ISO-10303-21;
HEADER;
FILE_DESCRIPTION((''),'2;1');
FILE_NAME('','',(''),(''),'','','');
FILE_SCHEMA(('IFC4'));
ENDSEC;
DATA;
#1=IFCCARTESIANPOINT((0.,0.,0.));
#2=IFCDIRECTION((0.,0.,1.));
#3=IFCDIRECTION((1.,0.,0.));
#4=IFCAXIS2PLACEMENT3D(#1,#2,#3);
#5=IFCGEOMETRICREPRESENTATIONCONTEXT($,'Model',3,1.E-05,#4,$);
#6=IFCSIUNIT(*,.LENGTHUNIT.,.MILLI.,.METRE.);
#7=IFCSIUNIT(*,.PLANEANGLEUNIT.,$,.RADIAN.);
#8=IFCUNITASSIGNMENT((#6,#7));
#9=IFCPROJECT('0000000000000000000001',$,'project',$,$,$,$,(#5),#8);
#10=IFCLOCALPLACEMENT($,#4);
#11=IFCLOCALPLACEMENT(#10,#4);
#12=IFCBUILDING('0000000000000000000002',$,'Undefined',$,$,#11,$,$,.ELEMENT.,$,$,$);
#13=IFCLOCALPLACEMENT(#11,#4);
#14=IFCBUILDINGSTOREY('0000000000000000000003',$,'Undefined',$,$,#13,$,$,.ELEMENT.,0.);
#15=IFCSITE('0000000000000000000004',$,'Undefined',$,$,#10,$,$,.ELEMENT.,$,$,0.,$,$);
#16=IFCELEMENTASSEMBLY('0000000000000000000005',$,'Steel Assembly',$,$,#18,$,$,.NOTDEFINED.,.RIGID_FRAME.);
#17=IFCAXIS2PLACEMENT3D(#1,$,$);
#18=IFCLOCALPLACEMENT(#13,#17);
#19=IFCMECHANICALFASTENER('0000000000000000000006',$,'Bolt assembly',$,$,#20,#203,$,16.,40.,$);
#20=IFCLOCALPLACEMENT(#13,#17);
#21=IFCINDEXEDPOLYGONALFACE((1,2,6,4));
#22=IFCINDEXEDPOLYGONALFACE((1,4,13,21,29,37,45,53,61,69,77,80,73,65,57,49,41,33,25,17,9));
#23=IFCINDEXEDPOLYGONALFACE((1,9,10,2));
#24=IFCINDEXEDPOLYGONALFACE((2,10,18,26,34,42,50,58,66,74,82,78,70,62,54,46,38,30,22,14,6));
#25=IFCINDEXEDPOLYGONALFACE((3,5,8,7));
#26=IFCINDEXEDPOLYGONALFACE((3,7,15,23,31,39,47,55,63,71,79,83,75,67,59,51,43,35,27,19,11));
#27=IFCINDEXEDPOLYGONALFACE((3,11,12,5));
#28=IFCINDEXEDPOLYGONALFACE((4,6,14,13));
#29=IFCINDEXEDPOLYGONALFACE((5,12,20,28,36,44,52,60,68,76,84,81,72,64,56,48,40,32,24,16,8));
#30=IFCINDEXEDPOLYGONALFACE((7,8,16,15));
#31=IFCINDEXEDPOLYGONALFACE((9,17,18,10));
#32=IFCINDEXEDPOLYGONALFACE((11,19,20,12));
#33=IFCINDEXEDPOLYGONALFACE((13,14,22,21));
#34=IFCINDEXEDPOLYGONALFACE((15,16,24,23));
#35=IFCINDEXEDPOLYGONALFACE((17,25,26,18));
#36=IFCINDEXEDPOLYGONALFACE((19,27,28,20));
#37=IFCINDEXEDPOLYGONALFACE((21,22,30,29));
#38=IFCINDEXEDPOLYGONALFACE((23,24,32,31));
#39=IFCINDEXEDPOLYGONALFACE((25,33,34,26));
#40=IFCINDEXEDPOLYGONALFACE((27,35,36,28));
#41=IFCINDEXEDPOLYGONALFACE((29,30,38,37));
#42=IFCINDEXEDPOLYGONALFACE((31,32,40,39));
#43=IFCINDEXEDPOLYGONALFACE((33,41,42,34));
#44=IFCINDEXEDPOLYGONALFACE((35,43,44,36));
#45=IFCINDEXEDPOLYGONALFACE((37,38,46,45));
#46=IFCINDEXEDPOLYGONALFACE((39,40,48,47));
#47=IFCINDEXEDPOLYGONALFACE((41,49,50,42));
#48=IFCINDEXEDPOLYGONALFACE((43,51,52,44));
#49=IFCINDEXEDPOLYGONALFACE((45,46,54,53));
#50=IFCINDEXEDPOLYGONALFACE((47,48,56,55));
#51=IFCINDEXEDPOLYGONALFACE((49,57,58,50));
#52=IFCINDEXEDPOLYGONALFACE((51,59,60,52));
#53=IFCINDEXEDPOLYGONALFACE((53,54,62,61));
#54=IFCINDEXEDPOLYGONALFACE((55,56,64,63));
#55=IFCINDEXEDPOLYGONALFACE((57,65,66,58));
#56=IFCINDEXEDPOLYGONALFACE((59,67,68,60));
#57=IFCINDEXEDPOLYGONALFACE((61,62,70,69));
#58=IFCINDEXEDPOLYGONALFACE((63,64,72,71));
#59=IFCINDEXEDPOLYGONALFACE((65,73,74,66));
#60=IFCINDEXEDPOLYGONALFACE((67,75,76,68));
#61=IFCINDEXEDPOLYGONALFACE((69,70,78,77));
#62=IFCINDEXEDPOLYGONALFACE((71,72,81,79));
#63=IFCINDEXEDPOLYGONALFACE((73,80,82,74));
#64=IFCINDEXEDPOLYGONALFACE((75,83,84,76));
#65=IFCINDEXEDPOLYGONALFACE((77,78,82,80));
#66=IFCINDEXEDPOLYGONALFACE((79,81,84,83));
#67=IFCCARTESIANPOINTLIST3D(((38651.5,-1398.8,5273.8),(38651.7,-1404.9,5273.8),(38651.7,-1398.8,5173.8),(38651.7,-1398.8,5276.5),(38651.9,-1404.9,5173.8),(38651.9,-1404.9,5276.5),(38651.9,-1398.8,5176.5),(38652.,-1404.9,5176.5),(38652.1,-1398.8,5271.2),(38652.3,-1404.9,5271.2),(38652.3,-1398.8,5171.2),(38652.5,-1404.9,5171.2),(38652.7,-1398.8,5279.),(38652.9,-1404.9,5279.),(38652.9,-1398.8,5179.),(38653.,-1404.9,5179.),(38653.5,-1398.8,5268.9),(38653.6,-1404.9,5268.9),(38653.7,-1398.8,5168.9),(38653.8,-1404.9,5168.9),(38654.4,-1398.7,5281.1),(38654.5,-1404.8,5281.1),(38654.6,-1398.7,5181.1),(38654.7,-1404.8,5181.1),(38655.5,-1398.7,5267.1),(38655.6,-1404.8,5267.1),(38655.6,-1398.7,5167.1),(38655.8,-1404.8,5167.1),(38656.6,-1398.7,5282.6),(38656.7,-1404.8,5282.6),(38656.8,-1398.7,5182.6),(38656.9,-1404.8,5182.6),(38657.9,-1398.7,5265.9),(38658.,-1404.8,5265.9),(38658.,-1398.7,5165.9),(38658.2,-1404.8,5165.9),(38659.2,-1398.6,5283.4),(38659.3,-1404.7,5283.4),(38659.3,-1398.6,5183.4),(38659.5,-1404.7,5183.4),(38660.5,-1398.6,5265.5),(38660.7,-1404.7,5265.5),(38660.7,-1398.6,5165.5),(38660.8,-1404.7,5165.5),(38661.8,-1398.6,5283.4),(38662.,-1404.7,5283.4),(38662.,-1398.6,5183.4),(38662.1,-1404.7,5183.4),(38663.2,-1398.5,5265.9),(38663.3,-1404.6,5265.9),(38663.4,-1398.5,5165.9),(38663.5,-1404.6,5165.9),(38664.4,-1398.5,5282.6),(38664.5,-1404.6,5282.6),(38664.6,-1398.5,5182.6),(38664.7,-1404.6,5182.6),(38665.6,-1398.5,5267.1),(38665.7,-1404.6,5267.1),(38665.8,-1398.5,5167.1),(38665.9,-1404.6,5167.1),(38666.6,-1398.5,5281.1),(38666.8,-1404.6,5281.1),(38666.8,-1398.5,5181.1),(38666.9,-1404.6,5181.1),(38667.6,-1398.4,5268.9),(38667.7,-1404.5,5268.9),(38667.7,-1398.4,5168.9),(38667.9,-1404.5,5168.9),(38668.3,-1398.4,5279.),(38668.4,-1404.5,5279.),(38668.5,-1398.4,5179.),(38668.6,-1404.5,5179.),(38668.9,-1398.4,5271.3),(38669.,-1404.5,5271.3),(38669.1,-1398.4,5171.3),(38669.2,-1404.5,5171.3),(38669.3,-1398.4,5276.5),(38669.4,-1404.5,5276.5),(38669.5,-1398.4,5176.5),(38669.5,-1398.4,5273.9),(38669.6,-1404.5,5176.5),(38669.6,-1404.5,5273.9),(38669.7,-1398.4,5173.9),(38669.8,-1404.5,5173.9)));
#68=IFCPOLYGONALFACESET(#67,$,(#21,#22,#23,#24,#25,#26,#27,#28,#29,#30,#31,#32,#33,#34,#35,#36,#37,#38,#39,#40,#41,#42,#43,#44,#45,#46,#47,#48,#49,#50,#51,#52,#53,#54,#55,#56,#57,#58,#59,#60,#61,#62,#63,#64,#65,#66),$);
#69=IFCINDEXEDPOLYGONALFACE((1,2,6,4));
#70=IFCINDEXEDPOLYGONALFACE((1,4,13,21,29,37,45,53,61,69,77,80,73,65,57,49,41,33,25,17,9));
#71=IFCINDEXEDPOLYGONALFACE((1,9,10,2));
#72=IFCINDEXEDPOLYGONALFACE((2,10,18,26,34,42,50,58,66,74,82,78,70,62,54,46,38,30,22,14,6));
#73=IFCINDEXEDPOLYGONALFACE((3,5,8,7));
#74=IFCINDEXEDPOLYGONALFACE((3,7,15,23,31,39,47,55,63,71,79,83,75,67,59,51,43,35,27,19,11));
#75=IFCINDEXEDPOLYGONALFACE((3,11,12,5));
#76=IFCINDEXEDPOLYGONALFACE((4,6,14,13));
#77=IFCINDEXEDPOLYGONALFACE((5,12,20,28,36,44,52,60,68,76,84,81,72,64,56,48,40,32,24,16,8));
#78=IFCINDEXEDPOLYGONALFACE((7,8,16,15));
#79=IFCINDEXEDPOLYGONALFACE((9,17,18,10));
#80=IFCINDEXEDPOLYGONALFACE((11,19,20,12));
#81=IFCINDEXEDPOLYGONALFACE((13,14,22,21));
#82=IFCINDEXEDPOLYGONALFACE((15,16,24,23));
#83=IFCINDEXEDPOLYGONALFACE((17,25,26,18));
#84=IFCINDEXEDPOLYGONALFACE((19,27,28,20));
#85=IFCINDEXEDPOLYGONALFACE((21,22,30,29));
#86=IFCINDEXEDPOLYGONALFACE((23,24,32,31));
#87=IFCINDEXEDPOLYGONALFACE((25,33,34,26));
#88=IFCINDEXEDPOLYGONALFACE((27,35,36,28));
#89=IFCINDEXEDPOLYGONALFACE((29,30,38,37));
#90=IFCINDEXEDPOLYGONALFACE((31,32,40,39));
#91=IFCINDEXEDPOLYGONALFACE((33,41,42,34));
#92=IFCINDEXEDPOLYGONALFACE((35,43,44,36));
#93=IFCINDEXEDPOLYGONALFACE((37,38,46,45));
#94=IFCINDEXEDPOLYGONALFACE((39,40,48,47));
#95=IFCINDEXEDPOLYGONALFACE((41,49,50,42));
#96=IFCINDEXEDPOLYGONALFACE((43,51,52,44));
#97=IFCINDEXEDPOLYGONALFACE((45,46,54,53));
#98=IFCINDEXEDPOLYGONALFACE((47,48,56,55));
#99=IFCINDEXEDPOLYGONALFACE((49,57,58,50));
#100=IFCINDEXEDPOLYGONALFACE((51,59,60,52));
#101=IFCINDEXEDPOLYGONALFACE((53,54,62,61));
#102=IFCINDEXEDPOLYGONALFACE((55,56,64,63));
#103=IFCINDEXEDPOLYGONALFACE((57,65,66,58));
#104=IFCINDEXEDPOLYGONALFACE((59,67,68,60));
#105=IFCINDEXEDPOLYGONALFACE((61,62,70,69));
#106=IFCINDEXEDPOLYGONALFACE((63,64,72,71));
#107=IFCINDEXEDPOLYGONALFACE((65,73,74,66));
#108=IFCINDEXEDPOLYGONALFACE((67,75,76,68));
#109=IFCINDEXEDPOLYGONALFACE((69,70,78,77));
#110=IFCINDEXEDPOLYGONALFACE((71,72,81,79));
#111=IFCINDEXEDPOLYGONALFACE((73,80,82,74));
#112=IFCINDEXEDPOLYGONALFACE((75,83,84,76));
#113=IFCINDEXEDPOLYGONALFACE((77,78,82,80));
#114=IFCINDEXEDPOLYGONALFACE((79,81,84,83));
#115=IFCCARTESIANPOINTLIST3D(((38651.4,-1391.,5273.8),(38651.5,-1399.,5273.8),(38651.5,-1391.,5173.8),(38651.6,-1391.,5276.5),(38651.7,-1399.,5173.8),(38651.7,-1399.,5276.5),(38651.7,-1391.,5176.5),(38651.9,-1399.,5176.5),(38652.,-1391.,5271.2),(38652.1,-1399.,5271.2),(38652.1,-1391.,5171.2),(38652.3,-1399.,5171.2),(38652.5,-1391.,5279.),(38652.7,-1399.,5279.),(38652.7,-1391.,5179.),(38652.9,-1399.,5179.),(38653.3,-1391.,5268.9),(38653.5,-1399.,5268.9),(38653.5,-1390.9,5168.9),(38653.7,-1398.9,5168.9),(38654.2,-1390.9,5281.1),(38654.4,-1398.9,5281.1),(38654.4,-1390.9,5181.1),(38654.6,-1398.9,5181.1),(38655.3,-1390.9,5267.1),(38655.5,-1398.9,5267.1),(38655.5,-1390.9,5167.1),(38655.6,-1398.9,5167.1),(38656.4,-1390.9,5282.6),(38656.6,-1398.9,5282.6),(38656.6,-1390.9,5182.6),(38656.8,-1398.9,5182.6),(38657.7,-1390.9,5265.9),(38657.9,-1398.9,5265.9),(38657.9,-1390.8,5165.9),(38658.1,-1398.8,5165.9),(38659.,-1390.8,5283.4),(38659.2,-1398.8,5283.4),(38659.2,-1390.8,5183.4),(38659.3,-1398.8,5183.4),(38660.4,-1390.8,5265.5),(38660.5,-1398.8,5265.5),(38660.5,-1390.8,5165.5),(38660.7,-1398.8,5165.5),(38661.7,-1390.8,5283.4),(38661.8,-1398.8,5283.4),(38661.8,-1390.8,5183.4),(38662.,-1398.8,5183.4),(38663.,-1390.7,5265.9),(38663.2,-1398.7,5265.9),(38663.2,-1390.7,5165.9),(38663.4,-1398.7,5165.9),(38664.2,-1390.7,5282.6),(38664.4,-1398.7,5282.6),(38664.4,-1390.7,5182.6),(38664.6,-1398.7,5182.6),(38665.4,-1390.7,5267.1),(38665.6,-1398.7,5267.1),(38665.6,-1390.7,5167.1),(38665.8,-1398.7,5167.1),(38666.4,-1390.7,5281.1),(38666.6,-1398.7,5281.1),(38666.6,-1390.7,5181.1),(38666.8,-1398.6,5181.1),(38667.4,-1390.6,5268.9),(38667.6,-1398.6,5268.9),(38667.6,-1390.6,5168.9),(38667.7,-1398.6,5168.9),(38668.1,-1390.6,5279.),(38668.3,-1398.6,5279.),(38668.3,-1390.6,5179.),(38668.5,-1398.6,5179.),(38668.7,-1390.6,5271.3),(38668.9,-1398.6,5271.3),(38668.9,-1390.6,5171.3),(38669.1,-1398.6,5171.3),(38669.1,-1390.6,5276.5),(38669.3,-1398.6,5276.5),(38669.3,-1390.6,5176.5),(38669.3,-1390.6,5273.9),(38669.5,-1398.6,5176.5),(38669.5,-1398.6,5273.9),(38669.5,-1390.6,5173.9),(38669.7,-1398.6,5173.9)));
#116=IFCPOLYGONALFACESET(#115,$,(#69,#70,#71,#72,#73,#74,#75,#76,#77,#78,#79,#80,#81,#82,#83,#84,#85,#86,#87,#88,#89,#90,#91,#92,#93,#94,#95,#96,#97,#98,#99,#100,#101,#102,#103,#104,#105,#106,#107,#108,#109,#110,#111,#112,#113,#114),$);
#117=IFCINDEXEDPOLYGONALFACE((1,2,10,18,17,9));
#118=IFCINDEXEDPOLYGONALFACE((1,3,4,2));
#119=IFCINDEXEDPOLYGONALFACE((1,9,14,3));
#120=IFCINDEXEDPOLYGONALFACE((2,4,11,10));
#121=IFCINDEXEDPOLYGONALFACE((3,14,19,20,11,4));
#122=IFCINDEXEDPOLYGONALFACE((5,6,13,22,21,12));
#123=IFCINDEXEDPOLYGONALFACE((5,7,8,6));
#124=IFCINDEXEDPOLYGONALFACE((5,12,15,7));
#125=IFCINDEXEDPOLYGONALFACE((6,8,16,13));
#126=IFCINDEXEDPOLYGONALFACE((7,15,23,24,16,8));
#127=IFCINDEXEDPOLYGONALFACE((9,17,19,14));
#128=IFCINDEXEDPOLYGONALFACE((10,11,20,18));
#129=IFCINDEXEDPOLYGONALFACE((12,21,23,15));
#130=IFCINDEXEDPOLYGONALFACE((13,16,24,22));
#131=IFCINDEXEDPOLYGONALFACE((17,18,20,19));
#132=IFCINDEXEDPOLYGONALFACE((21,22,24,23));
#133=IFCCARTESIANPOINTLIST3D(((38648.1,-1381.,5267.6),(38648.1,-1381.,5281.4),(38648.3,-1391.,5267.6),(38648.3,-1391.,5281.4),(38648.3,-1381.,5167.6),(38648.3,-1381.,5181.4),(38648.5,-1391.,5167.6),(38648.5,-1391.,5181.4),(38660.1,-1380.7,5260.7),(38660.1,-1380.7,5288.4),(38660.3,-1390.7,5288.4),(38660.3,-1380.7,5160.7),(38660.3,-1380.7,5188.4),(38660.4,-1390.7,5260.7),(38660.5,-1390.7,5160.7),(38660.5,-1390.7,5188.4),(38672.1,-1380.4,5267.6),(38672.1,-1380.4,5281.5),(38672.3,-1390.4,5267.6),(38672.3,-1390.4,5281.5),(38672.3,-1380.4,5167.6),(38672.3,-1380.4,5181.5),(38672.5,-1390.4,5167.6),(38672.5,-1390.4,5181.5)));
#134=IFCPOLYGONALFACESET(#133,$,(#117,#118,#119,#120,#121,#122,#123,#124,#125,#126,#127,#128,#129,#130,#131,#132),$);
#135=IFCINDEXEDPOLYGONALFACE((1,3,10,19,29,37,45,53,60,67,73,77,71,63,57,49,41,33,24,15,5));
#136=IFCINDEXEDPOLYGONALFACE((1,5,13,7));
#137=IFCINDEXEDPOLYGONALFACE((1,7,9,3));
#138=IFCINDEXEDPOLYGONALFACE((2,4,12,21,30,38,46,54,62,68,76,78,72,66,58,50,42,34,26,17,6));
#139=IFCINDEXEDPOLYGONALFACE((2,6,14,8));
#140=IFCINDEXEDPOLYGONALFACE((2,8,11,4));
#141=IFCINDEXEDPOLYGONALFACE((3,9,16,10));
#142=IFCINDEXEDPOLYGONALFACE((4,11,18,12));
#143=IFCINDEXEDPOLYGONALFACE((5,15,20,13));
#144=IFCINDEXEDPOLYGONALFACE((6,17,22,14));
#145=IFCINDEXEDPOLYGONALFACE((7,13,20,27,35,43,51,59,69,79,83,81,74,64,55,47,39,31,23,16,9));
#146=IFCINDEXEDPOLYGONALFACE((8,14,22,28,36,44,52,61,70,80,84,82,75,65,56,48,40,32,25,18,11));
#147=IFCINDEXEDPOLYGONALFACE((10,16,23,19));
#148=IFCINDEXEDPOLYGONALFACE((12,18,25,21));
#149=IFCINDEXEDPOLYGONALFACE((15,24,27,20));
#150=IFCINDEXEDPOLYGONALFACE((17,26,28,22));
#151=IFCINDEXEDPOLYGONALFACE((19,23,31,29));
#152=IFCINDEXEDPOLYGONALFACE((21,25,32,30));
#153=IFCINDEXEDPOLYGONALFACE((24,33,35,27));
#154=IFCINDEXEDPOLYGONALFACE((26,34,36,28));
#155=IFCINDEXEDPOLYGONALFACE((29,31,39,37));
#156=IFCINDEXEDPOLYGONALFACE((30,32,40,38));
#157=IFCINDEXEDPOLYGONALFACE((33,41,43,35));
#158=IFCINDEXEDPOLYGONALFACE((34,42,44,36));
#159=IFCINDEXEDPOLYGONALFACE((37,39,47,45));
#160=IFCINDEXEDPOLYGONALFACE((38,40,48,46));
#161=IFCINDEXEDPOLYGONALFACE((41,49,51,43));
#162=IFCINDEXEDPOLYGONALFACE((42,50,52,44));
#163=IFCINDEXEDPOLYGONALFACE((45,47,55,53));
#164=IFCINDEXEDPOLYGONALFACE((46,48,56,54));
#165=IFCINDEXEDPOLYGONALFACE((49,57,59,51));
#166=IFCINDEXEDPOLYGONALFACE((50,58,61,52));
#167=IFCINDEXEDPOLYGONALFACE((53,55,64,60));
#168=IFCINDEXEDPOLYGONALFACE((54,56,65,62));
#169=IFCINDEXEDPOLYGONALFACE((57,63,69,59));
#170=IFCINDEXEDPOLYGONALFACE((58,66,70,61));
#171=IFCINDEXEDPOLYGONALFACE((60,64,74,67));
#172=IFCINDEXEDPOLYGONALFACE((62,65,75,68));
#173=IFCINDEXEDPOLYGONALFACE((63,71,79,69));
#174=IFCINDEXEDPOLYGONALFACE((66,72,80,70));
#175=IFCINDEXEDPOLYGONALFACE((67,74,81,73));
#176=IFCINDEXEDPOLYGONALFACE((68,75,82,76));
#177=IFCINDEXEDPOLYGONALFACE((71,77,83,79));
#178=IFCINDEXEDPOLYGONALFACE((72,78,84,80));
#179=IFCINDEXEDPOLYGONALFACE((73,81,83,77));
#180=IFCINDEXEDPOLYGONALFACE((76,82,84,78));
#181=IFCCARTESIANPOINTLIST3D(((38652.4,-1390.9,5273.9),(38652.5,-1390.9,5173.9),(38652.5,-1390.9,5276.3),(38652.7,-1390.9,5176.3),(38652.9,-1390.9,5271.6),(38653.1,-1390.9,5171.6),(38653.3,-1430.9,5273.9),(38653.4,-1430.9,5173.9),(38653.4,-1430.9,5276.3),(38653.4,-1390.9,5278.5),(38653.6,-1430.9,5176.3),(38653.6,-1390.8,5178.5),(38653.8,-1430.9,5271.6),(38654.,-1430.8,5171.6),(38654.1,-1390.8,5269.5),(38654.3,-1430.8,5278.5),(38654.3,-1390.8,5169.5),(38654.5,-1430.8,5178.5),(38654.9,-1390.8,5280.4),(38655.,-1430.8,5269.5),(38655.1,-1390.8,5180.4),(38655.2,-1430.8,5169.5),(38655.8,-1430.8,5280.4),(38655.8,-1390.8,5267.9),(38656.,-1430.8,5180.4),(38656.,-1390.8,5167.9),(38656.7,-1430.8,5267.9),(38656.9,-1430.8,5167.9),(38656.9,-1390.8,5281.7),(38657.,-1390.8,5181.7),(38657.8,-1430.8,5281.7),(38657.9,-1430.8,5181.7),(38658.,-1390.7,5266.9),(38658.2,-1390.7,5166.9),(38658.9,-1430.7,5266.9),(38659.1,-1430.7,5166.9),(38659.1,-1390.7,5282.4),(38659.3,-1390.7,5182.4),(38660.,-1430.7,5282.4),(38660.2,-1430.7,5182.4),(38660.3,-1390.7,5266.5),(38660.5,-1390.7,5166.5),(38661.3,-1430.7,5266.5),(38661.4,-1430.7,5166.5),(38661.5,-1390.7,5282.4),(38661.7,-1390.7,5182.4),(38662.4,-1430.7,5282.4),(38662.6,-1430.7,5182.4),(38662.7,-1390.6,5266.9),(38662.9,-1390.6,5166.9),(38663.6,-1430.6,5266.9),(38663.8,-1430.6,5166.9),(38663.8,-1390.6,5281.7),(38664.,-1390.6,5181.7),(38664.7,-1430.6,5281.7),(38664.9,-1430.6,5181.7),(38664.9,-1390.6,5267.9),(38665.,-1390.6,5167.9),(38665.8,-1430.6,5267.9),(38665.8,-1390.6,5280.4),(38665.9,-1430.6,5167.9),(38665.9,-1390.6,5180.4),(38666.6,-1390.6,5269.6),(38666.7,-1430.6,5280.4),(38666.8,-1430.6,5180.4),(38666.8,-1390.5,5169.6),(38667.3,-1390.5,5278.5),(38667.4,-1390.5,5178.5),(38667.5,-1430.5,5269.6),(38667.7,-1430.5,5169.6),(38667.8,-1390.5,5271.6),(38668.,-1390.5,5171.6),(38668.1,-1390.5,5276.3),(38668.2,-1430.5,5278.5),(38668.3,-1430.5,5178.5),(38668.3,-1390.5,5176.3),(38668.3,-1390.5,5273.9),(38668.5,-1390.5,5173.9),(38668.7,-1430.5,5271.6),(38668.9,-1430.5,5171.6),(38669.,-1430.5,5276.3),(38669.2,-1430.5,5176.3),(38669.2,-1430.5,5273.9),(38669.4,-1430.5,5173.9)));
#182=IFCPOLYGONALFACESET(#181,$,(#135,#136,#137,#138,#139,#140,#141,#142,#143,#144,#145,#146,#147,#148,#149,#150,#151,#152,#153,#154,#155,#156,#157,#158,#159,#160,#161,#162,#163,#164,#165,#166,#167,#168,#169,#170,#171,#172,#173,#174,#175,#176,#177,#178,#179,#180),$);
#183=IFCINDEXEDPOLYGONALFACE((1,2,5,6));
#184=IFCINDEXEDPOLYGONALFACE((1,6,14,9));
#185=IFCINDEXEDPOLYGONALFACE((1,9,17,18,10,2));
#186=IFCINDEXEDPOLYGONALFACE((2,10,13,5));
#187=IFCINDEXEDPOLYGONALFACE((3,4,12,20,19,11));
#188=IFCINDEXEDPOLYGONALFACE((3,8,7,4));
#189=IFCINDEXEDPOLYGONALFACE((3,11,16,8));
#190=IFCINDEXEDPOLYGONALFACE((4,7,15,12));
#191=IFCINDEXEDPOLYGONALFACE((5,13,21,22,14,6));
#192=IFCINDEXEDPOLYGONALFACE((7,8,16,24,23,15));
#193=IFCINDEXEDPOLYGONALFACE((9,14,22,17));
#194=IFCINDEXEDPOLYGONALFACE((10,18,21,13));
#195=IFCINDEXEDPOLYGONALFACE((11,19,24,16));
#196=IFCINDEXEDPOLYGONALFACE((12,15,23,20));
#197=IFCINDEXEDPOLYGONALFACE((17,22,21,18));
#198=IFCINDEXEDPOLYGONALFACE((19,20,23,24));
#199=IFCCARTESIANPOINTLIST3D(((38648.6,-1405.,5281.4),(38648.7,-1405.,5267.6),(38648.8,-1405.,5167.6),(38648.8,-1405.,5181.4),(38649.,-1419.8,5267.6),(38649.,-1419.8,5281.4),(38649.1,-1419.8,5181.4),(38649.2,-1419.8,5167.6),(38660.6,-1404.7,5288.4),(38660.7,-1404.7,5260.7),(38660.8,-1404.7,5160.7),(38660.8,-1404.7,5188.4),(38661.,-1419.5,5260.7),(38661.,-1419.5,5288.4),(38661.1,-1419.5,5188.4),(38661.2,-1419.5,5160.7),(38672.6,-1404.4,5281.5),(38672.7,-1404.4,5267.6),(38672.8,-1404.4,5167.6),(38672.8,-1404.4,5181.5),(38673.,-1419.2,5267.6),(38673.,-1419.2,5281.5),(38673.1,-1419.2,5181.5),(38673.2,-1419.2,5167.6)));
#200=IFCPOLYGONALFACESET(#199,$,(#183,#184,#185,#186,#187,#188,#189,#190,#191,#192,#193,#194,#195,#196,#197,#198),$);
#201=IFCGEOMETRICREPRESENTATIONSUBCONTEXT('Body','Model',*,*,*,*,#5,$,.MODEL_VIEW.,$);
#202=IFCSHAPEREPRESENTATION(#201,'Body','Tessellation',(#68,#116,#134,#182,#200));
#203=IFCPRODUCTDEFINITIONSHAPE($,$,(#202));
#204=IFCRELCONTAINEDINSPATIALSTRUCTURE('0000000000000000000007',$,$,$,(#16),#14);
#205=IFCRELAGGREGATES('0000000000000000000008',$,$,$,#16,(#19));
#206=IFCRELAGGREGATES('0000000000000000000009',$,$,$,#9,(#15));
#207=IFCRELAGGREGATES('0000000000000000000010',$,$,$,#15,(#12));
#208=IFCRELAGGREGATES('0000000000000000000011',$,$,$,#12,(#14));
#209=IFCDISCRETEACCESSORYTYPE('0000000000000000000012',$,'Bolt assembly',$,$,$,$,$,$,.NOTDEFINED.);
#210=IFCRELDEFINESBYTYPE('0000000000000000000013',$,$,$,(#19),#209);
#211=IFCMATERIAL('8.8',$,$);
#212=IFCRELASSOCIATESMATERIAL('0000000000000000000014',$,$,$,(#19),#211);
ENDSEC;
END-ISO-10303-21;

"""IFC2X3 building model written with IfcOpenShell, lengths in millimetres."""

from ifc_helpers import new_model, si_unit, frame, origin_with_axes, origin_2d_with_axis, place, context, subcontext, project, spatial, polyline, circle, outline, extrude, source, transform, mapped, material, type_object, element, aggregate, save


model = new_model("IFC2X3")

# Units and contexts
model_context = context("Model", 3, precision=1e-05, world=origin_with_axes())
body_context = subcontext(model_context, "Body", "Model", "MODEL_VIEW")
ifc_project = project(units=[si_unit("LENGTHUNIT", "METRE", prefix="MILLI"), si_unit("PLANEANGLEUNIT", "RADIAN")], contexts=[model_context])

# Site, building, storey
site_placement = place(None, origin_with_axes())
site = spatial("IfcSite", under=ifc_project, at=site_placement, Name="Undefined", CompositionType="ELEMENT", RefElevation=0.0)
building_placement = place(site_placement, origin_with_axes())
building = spatial("IfcBuilding", under=site, at=building_placement, Name="Undefined", CompositionType="ELEMENT")
storey_placement = place(building_placement, origin_with_axes())
storey = spatial("IfcBuildingStorey", under=building, at=storey_placement, Name="Undefined", CompositionType="ELEMENT", Elevation=0.0)

# Element assembly
assembly_1_placement = place(storey_placement, origin_with_axes())
assembly_1 = element("IfcElementAssembly", 1, at=assembly_1_placement, inside=storey, Name="Steel Assembly", AssemblyPlace="NOTDEFINED", PredefinedType="RIGID_FRAME")

# Shared definitions
discrete_accessory_type_1 = type_object("IfcDiscreteAccessoryType", Name="Bolt assembly")

# Shared definitions
ifc_material_1 = material(Name="8.8")

# Mechanical fastener
shared_shape_1 = source(origin_with_axes(), body_context, "Body", "SweptSolid", [
    extrude(circle(Radius=9.0, at=origin_2d_with_axis()), frame((0.0, -0.1, 0.0), z_axis=(0.0, 1.0, 0.0), x_axis=(1.0, 0.0, 0.0)), (0.0, 0.0, 1.0), 6.1),
    extrude(circle(Radius=9.0, at=origin_2d_with_axis()), frame((0.0, -7.9, 0.0), z_axis=(0.0, 1.0, 0.0), x_axis=(1.0, 0.0, 0.0)), (0.0, 0.0, 1.0), 8.0),
    extrude(outline(polyline([(13.9, 0.0), (6.9, 12.0), (-6.9, 12.0), (-13.9, 0.0), (-6.9, -12.0), (6.9, -12.0), (13.9, 0.0)])), frame((0.0, -18.0, 0.0), z_axis=(0.0, 1.0, 0.0), x_axis=(1.0, 0.0, 0.0)), (0.0, 0.0, 1.0), 10.0),
    extrude(circle(Radius=8.0, at=origin_2d_with_axis()), frame((0.0, -8.0, 0.0), z_axis=(0.0, 1.0, 0.0), x_axis=(1.0, 0.0, 0.0)), (0.0, 0.0, 1.0), 40.0),
    extrude(outline(polyline([(13.9, 0.0), (6.9, 12.0), (-6.9, 12.0), (-13.9, 0.0), (-6.9, -12.0), (6.9, -12.0), (13.9, 0.0)])), frame((0.0, 6.0, 0.0), z_axis=(0.0, 1.0, 0.0), x_axis=(1.0, 0.0, 0.0)), (0.0, 0.0, 1.0), 14.8),
])
mechanical_fastener_1_placement = place(assembly_1_placement, frame((38660.5, -1398.7, 5274.5), z_axis=(-0.999743, -0.022588, -0.001724), x_axis=(0.001722, 0.000078, -0.999999)))
mechanical_fastener_1 = element("IfcMechanicalFastener", 2, at=mechanical_fastener_1_placement, type_object=discrete_accessory_type_1, material=ifc_material_1, Name="Bolt assembly", NominalDiameter=16.0, NominalLength=40.0, context=body_context, shape_type="MappedRepresentation", body=[
    mapped(shared_shape_1, transform((0.0, 0.0, 0.0))),
    mapped(shared_shape_1, transform((100.0, 0.0, 0.0))),
])
aggregate(assembly_1, [mechanical_fastener_1])

save(model, "model.ifc")
